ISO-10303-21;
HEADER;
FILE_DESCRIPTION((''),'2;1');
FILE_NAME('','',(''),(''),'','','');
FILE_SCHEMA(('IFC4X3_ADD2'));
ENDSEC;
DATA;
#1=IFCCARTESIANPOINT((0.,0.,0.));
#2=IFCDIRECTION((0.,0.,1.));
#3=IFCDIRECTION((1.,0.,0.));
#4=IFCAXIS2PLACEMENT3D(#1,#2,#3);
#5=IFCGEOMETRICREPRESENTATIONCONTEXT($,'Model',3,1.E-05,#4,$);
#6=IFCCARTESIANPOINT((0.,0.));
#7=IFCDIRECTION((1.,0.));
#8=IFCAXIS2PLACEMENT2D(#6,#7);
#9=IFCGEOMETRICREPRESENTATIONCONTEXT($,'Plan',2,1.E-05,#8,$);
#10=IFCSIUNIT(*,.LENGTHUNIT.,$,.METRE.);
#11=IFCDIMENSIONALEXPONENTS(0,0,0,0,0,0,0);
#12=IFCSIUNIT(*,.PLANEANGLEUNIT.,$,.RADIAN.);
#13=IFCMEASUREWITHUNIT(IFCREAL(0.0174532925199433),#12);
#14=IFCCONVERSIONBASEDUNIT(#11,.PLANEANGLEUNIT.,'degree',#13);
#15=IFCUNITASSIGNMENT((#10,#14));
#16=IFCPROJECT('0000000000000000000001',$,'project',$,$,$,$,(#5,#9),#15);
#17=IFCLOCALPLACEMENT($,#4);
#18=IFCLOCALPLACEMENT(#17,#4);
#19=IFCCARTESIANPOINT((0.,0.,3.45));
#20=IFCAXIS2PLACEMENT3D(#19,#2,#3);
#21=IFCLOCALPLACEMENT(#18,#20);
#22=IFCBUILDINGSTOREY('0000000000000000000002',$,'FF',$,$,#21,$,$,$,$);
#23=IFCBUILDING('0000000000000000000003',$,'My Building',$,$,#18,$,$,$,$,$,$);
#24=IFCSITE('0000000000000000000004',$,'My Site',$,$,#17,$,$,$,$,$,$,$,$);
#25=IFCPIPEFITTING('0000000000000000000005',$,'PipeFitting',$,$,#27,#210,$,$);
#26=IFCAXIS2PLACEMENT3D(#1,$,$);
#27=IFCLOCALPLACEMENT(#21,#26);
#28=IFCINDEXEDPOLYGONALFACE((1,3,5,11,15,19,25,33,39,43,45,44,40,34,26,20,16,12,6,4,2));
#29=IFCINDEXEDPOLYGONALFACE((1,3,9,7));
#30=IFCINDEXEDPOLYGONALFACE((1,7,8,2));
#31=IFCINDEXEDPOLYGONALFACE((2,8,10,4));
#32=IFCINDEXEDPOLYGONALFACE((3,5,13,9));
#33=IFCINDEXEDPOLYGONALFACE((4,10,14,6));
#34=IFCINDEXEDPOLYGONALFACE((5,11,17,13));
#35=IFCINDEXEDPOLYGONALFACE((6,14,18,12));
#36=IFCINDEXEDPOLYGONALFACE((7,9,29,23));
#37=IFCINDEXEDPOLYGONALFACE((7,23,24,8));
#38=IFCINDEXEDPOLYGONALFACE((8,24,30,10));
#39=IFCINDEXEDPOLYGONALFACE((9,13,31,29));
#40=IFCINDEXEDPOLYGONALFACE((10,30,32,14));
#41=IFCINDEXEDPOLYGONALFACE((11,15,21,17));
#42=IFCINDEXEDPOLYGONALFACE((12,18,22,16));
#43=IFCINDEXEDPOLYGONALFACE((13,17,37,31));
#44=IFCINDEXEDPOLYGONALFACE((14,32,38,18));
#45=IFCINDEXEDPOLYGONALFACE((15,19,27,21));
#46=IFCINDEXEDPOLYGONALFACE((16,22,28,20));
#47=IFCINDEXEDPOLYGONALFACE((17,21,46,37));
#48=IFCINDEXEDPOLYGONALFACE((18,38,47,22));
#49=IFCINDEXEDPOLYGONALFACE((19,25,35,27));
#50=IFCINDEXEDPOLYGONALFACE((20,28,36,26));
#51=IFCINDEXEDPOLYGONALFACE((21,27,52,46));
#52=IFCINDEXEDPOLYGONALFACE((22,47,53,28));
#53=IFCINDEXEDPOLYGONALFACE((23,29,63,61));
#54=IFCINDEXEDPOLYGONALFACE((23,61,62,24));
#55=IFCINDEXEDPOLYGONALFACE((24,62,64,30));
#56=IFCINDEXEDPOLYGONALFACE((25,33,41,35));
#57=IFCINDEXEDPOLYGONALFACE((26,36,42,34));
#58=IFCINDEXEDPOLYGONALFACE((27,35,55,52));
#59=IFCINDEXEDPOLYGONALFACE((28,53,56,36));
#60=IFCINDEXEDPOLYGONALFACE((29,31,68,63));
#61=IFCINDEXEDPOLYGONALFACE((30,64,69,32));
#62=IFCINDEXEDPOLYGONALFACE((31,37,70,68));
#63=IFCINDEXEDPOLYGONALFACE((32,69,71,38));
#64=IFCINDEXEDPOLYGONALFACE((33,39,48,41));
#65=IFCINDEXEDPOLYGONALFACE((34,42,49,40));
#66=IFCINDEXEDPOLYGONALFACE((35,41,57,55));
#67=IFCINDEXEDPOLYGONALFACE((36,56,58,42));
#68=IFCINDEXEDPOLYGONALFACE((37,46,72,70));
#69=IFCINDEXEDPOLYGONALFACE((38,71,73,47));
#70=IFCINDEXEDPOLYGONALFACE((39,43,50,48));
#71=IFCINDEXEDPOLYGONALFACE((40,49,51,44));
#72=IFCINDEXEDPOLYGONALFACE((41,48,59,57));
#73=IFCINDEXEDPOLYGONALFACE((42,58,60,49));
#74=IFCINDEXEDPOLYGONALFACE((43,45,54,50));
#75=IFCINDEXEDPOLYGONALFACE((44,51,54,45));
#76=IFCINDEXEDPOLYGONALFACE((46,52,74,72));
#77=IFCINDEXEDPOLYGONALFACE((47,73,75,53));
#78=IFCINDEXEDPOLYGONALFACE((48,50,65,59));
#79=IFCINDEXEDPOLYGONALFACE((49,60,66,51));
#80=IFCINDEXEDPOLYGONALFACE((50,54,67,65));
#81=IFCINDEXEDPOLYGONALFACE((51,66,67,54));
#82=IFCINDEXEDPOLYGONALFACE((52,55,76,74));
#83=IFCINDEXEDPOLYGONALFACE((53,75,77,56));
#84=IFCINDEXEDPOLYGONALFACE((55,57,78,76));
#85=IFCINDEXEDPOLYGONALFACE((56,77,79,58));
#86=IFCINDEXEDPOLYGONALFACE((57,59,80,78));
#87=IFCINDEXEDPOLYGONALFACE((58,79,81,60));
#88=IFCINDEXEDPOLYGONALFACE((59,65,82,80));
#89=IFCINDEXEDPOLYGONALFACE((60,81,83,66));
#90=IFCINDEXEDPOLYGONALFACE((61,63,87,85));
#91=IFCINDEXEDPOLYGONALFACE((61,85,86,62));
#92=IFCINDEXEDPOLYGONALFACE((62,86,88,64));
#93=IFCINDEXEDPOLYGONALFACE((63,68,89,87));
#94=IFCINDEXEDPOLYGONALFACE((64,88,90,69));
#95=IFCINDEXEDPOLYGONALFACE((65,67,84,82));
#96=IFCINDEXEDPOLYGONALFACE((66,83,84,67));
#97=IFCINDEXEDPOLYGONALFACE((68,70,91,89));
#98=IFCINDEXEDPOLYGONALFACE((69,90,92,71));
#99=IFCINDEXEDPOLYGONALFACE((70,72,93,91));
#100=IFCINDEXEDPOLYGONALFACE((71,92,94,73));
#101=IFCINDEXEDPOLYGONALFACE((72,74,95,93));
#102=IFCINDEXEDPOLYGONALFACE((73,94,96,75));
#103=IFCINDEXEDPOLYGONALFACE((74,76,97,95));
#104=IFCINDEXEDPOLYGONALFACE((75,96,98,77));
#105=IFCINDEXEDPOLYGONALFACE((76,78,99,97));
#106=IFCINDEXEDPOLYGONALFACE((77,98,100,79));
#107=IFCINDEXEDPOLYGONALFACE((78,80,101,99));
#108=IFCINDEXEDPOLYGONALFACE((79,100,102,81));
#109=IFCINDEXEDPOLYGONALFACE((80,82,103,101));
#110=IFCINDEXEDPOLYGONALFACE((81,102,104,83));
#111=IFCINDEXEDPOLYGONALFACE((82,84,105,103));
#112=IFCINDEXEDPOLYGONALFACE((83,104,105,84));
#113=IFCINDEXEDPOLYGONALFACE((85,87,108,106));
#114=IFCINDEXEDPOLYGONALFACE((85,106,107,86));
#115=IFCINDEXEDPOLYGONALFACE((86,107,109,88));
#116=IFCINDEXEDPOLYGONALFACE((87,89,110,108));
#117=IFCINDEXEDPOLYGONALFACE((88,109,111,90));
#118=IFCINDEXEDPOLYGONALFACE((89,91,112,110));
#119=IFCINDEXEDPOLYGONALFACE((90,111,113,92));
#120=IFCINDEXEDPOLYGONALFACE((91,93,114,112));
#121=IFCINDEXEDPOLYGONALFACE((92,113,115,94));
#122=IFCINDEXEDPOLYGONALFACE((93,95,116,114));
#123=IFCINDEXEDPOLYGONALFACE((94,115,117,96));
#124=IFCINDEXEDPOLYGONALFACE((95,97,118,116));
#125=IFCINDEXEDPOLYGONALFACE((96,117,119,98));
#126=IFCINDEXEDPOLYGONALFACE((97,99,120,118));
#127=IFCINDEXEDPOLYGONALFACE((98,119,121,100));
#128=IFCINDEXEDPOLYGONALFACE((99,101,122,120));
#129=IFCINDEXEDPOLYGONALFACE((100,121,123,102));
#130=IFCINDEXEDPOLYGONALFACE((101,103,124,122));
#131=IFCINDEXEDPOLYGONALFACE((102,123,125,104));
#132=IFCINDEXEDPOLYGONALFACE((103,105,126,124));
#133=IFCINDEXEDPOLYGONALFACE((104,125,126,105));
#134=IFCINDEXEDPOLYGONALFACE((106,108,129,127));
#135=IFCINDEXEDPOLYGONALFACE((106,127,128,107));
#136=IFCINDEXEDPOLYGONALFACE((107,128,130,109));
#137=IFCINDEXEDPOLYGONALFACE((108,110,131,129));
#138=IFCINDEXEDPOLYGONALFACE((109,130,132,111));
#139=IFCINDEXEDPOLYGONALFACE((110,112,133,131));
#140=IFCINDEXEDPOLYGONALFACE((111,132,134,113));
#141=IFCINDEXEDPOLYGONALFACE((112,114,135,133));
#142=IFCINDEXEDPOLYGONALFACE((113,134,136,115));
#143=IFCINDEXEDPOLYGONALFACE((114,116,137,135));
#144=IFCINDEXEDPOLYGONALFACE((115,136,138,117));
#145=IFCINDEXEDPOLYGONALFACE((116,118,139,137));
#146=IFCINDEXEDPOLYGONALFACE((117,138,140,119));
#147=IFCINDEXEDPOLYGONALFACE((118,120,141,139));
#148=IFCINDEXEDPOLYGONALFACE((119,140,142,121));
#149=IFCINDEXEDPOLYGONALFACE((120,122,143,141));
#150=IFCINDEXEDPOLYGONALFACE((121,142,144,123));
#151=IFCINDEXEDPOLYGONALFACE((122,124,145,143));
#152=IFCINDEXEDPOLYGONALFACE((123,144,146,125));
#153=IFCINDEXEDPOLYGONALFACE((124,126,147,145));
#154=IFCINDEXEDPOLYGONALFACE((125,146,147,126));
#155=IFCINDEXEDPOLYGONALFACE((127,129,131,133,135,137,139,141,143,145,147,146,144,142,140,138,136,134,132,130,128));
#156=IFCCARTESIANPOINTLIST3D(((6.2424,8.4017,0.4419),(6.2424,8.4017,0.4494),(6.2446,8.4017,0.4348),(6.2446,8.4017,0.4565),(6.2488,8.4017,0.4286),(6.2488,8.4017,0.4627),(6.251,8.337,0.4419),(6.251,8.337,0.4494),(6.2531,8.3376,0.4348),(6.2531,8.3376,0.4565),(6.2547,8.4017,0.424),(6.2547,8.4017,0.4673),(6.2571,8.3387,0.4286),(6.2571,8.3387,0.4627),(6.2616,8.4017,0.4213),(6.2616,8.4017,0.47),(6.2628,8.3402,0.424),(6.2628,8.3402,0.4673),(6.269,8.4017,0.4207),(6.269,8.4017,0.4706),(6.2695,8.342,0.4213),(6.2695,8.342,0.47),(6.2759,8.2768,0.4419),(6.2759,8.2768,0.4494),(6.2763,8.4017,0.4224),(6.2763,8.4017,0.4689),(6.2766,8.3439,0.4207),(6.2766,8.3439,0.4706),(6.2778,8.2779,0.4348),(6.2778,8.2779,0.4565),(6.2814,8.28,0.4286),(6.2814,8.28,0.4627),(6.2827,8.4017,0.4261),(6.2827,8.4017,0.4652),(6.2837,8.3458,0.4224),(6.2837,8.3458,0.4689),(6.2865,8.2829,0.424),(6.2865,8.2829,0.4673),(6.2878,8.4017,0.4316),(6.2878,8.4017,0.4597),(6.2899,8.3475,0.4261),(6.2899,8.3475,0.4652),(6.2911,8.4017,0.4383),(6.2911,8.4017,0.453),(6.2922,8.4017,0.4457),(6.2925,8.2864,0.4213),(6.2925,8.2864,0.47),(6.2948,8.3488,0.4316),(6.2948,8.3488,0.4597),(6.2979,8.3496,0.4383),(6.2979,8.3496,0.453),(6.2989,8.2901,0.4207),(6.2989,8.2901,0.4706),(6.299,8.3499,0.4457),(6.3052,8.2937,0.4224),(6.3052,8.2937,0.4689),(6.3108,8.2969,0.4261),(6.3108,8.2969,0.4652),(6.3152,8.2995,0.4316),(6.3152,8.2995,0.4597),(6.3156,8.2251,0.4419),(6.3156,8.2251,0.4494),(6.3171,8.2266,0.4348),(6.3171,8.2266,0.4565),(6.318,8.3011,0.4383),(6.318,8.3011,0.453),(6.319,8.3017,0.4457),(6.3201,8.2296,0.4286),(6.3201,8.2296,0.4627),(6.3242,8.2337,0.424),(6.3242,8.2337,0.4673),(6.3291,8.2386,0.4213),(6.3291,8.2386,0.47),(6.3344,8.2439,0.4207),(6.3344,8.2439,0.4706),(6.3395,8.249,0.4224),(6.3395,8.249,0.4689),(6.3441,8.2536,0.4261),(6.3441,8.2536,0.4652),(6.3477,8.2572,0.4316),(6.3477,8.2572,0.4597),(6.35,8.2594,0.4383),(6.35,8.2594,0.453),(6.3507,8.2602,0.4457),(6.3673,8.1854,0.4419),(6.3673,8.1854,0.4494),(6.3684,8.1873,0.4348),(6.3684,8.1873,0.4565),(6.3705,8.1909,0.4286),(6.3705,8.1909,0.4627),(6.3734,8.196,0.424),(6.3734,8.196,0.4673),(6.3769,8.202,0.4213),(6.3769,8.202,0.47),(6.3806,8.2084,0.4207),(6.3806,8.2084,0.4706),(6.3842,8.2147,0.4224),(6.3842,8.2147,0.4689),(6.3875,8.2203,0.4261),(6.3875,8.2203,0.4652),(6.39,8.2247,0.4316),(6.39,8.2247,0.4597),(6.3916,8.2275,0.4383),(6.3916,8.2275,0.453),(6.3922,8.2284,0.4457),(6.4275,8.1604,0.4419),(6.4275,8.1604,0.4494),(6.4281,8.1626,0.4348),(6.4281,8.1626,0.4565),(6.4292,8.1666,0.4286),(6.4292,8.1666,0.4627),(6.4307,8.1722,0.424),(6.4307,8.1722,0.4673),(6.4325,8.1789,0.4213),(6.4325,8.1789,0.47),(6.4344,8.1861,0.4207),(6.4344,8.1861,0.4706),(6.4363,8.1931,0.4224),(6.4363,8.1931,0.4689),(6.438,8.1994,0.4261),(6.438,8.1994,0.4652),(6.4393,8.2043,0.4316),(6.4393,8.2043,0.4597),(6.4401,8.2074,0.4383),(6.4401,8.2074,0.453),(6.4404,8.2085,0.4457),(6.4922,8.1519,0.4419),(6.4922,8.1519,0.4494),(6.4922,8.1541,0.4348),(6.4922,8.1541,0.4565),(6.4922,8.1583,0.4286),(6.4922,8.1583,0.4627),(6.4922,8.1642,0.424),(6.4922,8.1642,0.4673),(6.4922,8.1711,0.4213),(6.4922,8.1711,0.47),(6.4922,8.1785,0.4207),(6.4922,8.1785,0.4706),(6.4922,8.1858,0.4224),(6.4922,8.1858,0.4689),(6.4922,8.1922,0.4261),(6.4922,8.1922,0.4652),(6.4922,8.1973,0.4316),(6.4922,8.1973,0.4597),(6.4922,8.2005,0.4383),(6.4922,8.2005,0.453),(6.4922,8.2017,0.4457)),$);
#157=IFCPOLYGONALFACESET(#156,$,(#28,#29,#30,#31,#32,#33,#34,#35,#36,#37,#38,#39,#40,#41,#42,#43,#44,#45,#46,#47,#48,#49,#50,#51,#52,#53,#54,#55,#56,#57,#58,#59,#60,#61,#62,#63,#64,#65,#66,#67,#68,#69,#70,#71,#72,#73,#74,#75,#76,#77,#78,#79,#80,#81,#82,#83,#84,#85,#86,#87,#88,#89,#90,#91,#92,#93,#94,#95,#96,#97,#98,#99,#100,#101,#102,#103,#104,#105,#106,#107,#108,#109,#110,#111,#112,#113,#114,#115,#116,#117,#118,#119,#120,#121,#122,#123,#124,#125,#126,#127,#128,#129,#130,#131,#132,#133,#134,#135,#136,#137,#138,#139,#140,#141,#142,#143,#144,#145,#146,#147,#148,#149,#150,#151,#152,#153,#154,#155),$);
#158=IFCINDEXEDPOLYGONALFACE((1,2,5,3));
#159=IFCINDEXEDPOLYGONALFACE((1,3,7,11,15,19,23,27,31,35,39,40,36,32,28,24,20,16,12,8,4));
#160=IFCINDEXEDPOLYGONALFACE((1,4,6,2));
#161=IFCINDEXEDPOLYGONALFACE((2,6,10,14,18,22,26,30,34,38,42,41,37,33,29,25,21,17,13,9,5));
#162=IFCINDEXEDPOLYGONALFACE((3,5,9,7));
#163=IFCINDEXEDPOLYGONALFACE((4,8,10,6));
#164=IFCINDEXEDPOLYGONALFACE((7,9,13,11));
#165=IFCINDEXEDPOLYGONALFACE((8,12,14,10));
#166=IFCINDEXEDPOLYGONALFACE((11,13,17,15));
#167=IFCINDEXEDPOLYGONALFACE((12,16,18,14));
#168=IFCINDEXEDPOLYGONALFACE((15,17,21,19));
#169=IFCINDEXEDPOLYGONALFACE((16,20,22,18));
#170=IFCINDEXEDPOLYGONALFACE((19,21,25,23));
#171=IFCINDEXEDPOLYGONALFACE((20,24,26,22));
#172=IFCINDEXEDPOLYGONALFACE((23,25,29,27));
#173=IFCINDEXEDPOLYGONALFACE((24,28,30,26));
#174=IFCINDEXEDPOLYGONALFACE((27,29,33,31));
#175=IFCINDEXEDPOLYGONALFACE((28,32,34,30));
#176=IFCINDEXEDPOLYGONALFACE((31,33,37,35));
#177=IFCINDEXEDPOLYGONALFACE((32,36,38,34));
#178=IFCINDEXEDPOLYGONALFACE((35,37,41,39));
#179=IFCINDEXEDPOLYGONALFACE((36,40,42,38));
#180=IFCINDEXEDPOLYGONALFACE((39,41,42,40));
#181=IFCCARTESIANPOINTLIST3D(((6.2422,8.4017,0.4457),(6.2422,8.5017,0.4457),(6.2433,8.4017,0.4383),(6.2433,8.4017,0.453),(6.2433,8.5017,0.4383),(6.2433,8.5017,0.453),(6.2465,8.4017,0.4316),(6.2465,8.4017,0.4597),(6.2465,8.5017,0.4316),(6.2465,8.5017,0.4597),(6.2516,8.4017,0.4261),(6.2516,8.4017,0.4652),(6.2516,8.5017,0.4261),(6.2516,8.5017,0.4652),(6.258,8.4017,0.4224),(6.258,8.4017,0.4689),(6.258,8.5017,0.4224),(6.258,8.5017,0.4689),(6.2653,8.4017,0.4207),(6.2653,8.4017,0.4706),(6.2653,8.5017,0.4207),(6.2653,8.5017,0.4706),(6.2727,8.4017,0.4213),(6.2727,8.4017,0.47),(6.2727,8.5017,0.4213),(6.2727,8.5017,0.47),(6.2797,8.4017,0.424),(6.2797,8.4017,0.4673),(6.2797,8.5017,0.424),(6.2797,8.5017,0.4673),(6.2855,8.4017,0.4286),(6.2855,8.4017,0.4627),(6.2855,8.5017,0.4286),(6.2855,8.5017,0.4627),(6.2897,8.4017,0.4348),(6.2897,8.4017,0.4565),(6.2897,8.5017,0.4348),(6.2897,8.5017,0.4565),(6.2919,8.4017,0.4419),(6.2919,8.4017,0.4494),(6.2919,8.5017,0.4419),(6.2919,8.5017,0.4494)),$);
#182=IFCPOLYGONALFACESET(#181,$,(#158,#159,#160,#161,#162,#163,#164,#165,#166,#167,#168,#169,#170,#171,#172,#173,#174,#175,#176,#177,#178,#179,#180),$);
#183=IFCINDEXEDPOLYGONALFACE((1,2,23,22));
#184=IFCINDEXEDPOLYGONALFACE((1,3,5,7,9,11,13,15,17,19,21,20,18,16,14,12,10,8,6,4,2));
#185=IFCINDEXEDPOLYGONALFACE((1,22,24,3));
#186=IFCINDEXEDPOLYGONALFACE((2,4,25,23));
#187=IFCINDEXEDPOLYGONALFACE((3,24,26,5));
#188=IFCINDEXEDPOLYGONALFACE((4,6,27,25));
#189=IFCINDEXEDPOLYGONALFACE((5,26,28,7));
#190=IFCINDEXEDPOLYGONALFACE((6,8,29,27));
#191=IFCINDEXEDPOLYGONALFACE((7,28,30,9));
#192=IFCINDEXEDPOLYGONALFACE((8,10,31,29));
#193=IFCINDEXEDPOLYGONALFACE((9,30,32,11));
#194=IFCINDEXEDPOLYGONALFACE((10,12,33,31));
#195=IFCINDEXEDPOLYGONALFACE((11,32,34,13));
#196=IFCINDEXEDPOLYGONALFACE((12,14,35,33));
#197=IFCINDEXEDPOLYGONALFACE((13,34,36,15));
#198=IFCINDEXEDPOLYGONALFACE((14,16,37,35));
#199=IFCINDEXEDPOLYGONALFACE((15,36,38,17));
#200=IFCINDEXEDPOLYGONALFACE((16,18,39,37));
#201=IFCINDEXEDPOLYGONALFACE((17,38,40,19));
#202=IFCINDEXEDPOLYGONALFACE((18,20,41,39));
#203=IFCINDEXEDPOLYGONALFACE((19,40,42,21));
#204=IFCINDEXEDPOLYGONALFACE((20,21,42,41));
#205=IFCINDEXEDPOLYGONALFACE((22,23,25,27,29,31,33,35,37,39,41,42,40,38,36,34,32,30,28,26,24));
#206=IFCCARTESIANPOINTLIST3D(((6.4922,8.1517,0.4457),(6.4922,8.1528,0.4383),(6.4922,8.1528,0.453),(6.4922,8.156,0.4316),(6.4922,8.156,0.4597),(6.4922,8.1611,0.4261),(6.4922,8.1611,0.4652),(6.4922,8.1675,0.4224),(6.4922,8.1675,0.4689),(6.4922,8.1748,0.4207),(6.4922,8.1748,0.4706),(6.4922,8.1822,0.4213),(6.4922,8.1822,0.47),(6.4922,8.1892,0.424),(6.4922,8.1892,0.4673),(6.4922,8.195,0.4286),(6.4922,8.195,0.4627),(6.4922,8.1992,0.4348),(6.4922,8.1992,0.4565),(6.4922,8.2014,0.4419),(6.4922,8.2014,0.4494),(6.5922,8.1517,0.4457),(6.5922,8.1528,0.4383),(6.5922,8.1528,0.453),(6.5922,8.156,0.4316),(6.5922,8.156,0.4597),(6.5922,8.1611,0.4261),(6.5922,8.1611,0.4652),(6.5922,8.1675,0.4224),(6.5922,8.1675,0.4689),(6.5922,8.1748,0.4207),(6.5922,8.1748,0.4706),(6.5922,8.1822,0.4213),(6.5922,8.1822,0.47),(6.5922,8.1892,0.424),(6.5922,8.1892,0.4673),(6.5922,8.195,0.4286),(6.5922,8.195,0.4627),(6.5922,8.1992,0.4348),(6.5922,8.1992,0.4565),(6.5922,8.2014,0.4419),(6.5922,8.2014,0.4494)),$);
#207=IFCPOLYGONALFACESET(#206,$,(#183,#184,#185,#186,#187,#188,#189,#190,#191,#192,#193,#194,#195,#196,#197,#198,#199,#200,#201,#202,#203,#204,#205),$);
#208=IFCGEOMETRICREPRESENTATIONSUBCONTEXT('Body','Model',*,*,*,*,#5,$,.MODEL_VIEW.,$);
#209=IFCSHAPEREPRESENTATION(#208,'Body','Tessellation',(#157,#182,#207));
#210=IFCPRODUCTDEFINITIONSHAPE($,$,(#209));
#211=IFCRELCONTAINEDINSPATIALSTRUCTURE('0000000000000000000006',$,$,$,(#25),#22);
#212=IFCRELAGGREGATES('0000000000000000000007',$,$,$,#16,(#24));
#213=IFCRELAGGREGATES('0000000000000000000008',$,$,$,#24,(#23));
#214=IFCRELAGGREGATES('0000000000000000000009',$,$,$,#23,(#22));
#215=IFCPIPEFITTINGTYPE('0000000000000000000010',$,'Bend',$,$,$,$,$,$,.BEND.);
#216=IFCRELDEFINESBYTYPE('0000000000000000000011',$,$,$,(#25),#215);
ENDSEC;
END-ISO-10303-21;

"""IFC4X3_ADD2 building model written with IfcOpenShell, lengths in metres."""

from ifc_helpers import new_model, entity, si_unit, converted_unit, frame, origin_with_axes, origin_2d_with_axis, place, context, subcontext, project, spatial, circle, extrude, source, transform, mapped, type_object, type_shapes, element, save


model = new_model("IFC4X3_ADD2")

# Units and contexts
model_context = context("Model", 3, precision=1e-05, world=origin_with_axes())
plan_context = context("Plan", 2, precision=1e-05, world=origin_2d_with_axis())
body_context_1 = subcontext(model_context, "Body", "Model", "MODEL_VIEW")
ifc_project = project(units=[si_unit("LENGTHUNIT", "METRE"), converted_unit("PLANEANGLEUNIT", "degree", entity("IfcReal", 0.0174532925199433), si_unit("PLANEANGLEUNIT", "RADIAN"), dimensions=[0, 0, 0, 0, 0, 0, 0])], contexts=[model_context, plan_context])

# Site, building, storey
site_placement = place(None, origin_with_axes())
site = spatial("IfcSite", under=ifc_project, at=site_placement, Name="My Site")
building_placement = place(site_placement, origin_with_axes())
building = spatial("IfcBuilding", under=site, at=building_placement, Name="My Building")
storey_placement = place(building_placement, frame((0.0, 0.0, 3.45), z_axis=(0.0, 0.0, 1.0), x_axis=(1.0, 0.0, 0.0)))
storey = spatial("IfcBuildingStorey", under=building, at=storey_placement, Name="FF")

# Pipe fitting
pipe_fitting_type = type_object("IfcPipeFittingType", Name="Bend", PredefinedType="BEND")
shared_shape_1 = source(origin_with_axes(), body_context_1, "Body", "SolidModel", [
    entity("IfcSweptDiskSolid", entity("IfcIndexedPolyCurve", entity("IfcCartesianPointList3D", [[0.0, 0.0, -0.1], [-0.0659, 0.0, -0.2591], [-0.225, 0.0, -0.325]]), [entity("IfcArcIndex", [1, 2, 3])]), 0.025),
    extrude(circle(Radius=0.025), origin_with_axes(), (0.0, 0.0, -1.0), 0.1),
    extrude(circle(Radius=0.025), frame((-0.225, 0.0, -0.325), z_axis=(-1.0, 0.0, 0.0), x_axis=(0.0, 0.0, -1.0)), (0.0, 0.0, 1.0), 0.1),
])
type_shapes(pipe_fitting_type, [shared_shape_1])
pipe_fitting_placement = place(storey_placement, frame((6.2672, 8.5017, 0.4457), z_axis=(0.0, 1.0, 0.0), x_axis=(-1.0, 0.0, 0.0)))
element("IfcPipeFitting", 1, at=pipe_fitting_placement, inside=storey, type_object=pipe_fitting_type, Name="PipeFitting", context=body_context_1, shape_type="MappedRepresentation", body=[
    mapped(shared_shape_1, transform((0.0, 0.0, 0.0), x_axis=(1.0, 0.0, 0.0), y_axis=(0.0, 1.0, 0.0), z_axis=(0.0, 0.0, 1.0), scale=1.0)),
])

save(model, "model.ifc")
